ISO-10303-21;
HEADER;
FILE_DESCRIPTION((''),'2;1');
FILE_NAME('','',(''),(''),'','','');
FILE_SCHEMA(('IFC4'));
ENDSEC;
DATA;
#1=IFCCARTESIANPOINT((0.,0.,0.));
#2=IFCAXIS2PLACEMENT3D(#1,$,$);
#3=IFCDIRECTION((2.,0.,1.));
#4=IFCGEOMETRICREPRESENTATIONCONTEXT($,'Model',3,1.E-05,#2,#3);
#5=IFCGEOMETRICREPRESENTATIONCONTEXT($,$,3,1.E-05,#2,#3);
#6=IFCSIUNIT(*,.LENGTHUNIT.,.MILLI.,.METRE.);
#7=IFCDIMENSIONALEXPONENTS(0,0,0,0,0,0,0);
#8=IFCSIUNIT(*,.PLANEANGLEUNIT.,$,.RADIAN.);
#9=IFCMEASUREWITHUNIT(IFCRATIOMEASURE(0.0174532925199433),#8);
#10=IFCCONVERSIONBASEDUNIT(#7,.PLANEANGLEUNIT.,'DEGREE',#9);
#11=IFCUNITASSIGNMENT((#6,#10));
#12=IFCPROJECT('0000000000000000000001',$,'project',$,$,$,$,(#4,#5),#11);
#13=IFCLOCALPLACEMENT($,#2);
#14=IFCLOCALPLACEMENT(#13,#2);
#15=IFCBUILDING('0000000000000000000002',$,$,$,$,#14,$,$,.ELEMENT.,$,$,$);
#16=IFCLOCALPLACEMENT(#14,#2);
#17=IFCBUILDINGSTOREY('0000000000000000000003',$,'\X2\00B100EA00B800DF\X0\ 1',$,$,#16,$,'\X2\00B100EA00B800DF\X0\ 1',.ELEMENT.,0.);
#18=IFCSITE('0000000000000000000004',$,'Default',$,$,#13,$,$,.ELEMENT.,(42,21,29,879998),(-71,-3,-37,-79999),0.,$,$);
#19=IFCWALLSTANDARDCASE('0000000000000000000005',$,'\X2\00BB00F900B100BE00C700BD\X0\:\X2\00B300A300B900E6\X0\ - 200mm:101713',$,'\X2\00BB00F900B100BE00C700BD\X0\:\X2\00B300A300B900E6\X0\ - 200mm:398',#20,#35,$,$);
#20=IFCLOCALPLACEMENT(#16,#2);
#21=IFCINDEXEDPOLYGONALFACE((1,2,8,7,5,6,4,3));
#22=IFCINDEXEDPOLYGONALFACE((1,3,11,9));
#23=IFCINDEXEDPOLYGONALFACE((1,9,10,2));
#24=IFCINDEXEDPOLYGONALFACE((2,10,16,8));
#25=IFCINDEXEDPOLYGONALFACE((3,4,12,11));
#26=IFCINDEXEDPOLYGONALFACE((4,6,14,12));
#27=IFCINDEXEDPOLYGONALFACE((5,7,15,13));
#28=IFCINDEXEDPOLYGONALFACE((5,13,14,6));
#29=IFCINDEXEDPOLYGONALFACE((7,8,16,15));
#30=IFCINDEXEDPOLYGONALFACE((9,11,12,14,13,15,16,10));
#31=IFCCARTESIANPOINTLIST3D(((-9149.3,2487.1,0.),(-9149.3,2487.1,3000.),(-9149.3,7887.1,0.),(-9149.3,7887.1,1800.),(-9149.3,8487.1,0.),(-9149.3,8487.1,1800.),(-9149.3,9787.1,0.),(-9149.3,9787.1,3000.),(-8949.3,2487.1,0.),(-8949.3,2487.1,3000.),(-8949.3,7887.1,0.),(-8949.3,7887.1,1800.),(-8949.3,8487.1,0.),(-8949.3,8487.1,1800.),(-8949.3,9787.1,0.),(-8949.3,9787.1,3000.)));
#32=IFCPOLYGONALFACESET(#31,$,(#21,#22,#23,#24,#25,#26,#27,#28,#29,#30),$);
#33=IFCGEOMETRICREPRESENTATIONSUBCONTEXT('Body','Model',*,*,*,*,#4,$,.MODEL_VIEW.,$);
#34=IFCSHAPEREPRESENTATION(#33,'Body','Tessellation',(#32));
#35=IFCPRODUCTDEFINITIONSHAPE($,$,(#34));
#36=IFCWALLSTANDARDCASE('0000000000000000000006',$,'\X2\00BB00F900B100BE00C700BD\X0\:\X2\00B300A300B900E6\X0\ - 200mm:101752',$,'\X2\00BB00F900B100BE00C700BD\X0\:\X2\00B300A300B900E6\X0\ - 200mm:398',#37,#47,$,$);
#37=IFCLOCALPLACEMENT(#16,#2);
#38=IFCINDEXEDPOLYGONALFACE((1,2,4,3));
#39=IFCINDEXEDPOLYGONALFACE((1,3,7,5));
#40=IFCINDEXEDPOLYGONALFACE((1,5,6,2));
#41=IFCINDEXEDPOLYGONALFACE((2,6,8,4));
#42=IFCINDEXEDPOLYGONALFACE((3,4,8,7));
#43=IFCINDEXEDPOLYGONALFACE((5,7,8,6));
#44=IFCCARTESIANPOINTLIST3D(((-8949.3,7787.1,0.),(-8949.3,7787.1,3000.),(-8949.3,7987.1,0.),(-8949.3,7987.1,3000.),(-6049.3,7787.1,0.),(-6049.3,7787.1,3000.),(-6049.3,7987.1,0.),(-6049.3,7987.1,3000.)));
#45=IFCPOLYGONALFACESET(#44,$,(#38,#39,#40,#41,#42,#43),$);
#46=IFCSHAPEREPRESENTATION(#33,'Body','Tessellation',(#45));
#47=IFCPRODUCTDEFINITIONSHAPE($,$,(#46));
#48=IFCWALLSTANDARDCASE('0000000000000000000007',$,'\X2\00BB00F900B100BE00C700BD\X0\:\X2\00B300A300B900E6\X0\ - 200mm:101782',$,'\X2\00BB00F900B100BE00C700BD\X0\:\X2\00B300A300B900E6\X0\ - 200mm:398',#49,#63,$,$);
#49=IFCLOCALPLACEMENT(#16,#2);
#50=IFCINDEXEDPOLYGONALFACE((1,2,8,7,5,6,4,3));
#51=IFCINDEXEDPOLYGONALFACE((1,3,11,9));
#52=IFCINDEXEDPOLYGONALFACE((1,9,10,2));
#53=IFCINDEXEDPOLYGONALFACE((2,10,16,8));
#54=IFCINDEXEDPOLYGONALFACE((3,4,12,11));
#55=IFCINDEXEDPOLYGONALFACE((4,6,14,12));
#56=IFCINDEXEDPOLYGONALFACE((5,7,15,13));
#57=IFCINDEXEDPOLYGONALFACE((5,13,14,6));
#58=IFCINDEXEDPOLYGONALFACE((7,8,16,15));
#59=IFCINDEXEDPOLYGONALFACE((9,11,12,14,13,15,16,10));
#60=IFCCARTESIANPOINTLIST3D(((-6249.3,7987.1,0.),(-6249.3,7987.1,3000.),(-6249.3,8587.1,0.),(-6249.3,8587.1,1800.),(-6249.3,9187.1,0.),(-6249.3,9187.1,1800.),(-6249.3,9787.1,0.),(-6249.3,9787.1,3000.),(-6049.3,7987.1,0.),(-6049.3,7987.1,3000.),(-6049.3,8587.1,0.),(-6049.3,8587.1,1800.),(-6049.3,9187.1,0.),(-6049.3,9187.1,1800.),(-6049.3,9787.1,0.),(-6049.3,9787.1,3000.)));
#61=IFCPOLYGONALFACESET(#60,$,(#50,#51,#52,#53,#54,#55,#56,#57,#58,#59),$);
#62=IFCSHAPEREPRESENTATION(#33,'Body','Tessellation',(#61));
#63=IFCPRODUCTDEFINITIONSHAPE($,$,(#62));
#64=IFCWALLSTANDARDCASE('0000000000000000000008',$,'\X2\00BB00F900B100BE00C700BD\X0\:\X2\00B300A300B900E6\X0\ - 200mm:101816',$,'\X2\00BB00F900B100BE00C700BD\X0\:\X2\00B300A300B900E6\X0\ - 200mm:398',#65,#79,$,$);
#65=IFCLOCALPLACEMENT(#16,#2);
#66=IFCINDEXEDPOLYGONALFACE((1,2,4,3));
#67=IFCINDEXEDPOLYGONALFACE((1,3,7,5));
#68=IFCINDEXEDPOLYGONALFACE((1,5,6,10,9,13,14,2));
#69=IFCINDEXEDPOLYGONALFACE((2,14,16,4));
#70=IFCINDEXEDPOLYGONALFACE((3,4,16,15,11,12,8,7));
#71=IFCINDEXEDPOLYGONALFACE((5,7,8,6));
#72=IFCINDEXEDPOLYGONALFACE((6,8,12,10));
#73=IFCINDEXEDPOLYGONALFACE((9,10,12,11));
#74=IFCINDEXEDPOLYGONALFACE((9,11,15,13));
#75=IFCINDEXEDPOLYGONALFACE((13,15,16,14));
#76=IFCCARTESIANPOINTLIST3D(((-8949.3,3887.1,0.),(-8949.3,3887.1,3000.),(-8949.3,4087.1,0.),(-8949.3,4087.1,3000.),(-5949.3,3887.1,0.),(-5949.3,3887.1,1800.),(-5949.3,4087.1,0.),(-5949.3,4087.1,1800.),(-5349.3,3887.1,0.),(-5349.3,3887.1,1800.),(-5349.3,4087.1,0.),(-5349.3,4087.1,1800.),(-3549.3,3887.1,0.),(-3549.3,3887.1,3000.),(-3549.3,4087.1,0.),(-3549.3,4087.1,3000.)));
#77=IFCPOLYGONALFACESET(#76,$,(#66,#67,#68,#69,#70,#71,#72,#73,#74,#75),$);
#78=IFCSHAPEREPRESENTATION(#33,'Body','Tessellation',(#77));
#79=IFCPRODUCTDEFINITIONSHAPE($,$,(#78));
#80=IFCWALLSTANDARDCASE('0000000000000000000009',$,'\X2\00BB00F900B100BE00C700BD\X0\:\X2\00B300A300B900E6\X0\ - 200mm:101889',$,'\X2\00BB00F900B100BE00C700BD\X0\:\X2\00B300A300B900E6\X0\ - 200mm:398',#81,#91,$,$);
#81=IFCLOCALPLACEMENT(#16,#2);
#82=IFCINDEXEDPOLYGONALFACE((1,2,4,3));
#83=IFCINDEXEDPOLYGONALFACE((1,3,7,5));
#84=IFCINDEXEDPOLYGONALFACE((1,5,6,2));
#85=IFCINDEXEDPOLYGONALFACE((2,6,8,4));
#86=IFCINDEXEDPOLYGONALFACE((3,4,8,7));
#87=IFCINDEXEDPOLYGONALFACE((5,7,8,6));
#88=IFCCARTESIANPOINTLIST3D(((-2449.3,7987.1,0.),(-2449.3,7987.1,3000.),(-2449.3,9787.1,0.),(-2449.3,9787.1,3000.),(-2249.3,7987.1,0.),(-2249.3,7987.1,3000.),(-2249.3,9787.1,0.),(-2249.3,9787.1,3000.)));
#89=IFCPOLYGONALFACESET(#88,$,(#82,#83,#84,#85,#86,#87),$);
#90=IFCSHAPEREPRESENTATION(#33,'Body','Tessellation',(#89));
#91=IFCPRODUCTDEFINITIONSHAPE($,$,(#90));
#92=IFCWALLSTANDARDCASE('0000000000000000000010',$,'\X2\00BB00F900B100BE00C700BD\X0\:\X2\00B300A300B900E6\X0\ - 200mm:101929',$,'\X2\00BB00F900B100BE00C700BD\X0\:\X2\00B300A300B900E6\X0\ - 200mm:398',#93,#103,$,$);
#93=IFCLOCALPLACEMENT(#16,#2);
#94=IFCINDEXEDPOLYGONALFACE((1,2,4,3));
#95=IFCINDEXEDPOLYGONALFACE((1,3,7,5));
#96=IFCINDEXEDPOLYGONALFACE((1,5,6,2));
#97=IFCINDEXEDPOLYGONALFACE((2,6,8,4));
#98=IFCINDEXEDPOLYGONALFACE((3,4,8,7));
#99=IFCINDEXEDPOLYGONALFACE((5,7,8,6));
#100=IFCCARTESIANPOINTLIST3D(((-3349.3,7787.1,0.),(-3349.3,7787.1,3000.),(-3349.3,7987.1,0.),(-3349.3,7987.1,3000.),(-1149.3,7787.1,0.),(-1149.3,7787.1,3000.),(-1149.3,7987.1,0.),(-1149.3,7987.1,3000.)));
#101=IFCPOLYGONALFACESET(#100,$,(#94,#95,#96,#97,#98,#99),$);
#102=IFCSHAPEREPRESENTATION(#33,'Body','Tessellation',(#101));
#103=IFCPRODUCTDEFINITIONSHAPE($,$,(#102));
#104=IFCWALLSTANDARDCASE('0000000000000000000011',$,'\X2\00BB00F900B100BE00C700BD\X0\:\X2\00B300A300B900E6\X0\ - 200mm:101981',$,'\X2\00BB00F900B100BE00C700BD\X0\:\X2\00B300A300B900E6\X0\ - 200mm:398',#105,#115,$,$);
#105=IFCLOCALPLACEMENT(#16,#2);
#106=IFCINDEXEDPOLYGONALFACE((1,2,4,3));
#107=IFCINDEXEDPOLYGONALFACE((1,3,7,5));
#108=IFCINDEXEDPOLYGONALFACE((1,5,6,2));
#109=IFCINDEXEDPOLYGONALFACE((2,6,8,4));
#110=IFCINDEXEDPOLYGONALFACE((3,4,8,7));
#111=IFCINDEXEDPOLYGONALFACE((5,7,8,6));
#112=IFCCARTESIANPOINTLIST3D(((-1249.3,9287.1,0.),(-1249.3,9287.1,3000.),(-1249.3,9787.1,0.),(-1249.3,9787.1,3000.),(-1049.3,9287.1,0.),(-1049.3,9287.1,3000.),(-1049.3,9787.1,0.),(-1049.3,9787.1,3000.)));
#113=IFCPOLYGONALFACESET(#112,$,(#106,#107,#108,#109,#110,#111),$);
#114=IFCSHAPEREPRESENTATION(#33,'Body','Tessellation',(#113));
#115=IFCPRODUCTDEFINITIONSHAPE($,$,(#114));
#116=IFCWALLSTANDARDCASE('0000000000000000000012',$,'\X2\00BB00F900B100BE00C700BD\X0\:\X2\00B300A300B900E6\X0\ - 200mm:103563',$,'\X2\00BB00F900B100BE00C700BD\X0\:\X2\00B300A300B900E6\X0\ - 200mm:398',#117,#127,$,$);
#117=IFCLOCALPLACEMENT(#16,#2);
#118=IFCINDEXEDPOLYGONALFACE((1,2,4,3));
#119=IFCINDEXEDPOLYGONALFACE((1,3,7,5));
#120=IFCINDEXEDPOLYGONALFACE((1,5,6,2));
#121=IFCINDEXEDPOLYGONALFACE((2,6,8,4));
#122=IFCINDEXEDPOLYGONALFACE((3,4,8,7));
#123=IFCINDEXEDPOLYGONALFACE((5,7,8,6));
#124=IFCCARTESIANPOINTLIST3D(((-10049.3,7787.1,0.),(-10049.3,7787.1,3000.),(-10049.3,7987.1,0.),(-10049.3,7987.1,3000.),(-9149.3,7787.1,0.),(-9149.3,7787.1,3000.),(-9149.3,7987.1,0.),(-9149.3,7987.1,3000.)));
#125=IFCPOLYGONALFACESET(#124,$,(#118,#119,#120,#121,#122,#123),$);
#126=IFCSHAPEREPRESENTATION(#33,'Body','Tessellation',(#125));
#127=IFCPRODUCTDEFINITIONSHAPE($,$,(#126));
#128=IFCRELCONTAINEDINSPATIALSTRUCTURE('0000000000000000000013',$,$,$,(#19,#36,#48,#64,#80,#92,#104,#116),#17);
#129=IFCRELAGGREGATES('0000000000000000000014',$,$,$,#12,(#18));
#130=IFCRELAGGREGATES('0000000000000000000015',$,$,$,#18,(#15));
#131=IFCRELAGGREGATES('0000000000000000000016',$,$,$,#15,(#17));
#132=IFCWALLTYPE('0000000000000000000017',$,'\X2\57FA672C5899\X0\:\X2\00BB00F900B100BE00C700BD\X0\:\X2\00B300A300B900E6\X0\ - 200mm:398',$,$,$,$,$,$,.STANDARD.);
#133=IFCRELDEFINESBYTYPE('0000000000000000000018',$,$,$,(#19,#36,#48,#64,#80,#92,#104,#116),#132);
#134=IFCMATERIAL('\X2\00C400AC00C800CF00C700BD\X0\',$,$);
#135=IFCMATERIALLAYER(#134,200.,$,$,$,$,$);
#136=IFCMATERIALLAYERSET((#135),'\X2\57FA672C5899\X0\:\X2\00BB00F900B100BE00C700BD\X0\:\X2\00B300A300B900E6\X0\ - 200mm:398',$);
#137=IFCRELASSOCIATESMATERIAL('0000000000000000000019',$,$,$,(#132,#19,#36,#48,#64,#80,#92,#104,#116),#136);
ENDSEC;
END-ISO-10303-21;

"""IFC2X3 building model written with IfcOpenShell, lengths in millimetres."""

from ifc_helpers import new_model, entity, si_unit, converted_unit, direction, frame, frame_2d, origin, origin_2d_with_axis, place, context, subcontext, project, spatial, rectangle, extrude, material, layer, layer_set, layer_usage, type_object, element, save


model = new_model("IFC2X3")

# Units and contexts
model_context = context("Model", 3, precision=1e-05, world=origin(), true_north=direction((2.0, 0.0, 1.0)))
context_of_model = context(None, 3, precision=1e-05, world=origin(), true_north=direction((2.0, 0.0, 1.0)))
body_context = subcontext(model_context, "Body", "Model", "MODEL_VIEW")
ifc_project = project(units=[si_unit("LENGTHUNIT", "METRE", prefix="MILLI"), converted_unit("PLANEANGLEUNIT", "DEGREE", entity("IfcRatioMeasure", 0.0174532925199433), si_unit("PLANEANGLEUNIT", "RADIAN"), dimensions=[0, 0, 0, 0, 0, 0, 0])], contexts=[model_context, context_of_model])

# Site, building, storey
site_placement = place(None, origin())
site = spatial("IfcSite", under=ifc_project, at=site_placement, Name="Default", CompositionType="ELEMENT", RefLatitude=(42, 21, 29, 879998), RefLongitude=(-71, -3, -37, -79999), RefElevation=0.0)
building_placement = place(site_placement, origin())
building = spatial("IfcBuilding", under=site, at=building_placement, CompositionType="ELEMENT")
storey_placement = place(building_placement, origin())
storey = spatial("IfcBuildingStorey", under=building, at=storey_placement, Name="±ê¸ß 1", LongName="±ê¸ß 1", CompositionType="ELEMENT", Elevation=0.0)

# Shared definitions
ifc_material = material(Name="Ä¬ÈÏÇ½")
ifc_layer = layer(ifc_material, 200.0)
ifc_layer_set = layer_set([ifc_layer], Name="基本墙:»ù±¾Ç½:³£¹æ - 200mm:398")
wall_type = type_object("IfcWallType", Name="基本墙:»ù±¾Ç½:³£¹æ - 200mm:398", PredefinedType="STANDARD", material=ifc_layer_set)

# Wall, opening
ifc_layer_usage_1 = layer_usage(ifc_layer_set, "AXIS2", "NEGATIVE", 100.0)
wall_1_placement = place(storey_placement, frame((-9049.3, 9787.1, 0.0), z_axis=(0.0, 0.0, 1.0), x_axis=(0.0, -1.0, 0.0)))
wall_1 = element("IfcWallStandardCase", 1, at=wall_1_placement, inside=storey, type_object=wall_type, material=ifc_layer_usage_1, Name="»ù±¾Ç½:³£¹æ - 200mm:101713", ObjectType="»ù±¾Ç½:³£¹æ - 200mm:398", context=body_context, shape_type="SweptSolid", body=[
    extrude(rectangle(XDim=7300.0, YDim=200.0, at=frame_2d((3650.0, 0.0), x_axis=(-1.0, 0.0))), origin(), (0.0, 0.0, 1.0), 3000.0),
])
opening_1_placement = place(wall_1_placement, origin())
element("IfcOpeningElement", 2, at=opening_1_placement, cuts=wall_1, ObjectType="Opening", context=body_context, shape_type="SweptSolid", body=[
    extrude(rectangle(XDim=1800.0, YDim=600.0, at=origin_2d_with_axis()), frame((1600.0, -102.0, 900.0), z_axis=(0.0, 1.0, 0.0), x_axis=(0.0, 0.0, -1.0)), (0.0, 0.0, 1.0), 204.0),
])

# Wall
ifc_layer_usage_2 = layer_usage(ifc_layer_set, "AXIS2", "NEGATIVE", 100.0)
wall_2_placement = place(storey_placement, frame((-8949.3, 7887.1, 0.0)))
element("IfcWallStandardCase", 3, at=wall_2_placement, inside=storey, type_object=wall_type, material=ifc_layer_usage_2, Name="»ù±¾Ç½:³£¹æ - 200mm:101752", ObjectType="»ù±¾Ç½:³£¹æ - 200mm:398", context=body_context, shape_type="SweptSolid", body=[
    extrude(rectangle(XDim=2900.0, YDim=200.0, at=frame_2d((1450.0, 0.0), x_axis=(-1.0, 0.0))), origin(), (0.0, 0.0, 1.0), 3000.0),
])

# Walls, openings
ifc_layer_usage_3 = layer_usage(ifc_layer_set, "AXIS2", "NEGATIVE", 100.0)
wall_3_placement = place(storey_placement, frame((-6149.3, 7987.1, 0.0), z_axis=(0.0, 0.0, 1.0), x_axis=(0.0, 1.0, 0.0)))
wall_3 = element("IfcWallStandardCase", 4, at=wall_3_placement, inside=storey, type_object=wall_type, material=ifc_layer_usage_3, Name="»ù±¾Ç½:³£¹æ - 200mm:101782", ObjectType="»ù±¾Ç½:³£¹æ - 200mm:398", context=body_context, shape_type="SweptSolid", body=[
    extrude(rectangle(XDim=1800.0, YDim=200.0, at=frame_2d((900.0, 0.0), x_axis=(-1.0, 0.0))), origin(), (0.0, 0.0, 1.0), 3000.0),
])
opening_2_placement = place(wall_3_placement, origin())
element("IfcOpeningElement", 5, at=opening_2_placement, cuts=wall_3, ObjectType="Opening", context=body_context, shape_type="SweptSolid", body=[
    extrude(rectangle(XDim=1800.0, YDim=600.0, at=frame_2d((0.0, 0.0), x_axis=(0.0, 1.0))), frame((900.0, -102.0, 900.0), z_axis=(0.0, 1.0, 0.0), x_axis=(1.0, 0.0, 0.0)), (0.0, 0.0, 1.0), 204.0),
])
ifc_layer_usage_4 = layer_usage(ifc_layer_set, "AXIS2", "NEGATIVE", 100.0)
wall_4_placement = place(storey_placement, frame((-8949.3, 3987.1, 0.0)))
wall_4 = element("IfcWallStandardCase", 6, at=wall_4_placement, inside=storey, type_object=wall_type, material=ifc_layer_usage_4, Name="»ù±¾Ç½:³£¹æ - 200mm:101816", ObjectType="»ù±¾Ç½:³£¹æ - 200mm:398", context=body_context, shape_type="SweptSolid", body=[
    extrude(rectangle(XDim=5400.0, YDim=200.0, at=frame_2d((2700.0, 0.0), x_axis=(-1.0, 0.0))), origin(), (0.0, 0.0, 1.0), 3000.0),
])
opening_3_placement = place(wall_4_placement, origin())
element("IfcOpeningElement", 7, at=opening_3_placement, cuts=wall_4, ObjectType="Opening", context=body_context, shape_type="SweptSolid", body=[
    extrude(rectangle(XDim=1800.0, YDim=600.0, at=frame_2d((0.0, 0.0), x_axis=(0.0, 1.0))), frame((3300.0, -102.0, 900.0), z_axis=(0.0, 1.0, 0.0), x_axis=(1.0, 0.0, 0.0)), (0.0, 0.0, 1.0), 204.0),
])

# Walls
ifc_layer_usage_5 = layer_usage(ifc_layer_set, "AXIS2", "NEGATIVE", 100.0)
wall_5_placement = place(storey_placement, frame((-2349.3, 9787.1, 0.0), z_axis=(0.0, 0.0, 1.0), x_axis=(0.0, -1.0, 0.0)))
element("IfcWallStandardCase", 8, at=wall_5_placement, inside=storey, type_object=wall_type, material=ifc_layer_usage_5, Name="»ù±¾Ç½:³£¹æ - 200mm:101889", ObjectType="»ù±¾Ç½:³£¹æ - 200mm:398", context=body_context, shape_type="SweptSolid", body=[
    extrude(rectangle(XDim=1800.0, YDim=200.0, at=frame_2d((900.0, 0.0), x_axis=(-1.0, 0.0))), origin(), (0.0, 0.0, 1.0), 3000.0),
])
ifc_layer_usage_6 = layer_usage(ifc_layer_set, "AXIS2", "NEGATIVE", 100.0)
wall_6_placement = place(storey_placement, frame((-3349.3, 7887.1, 0.0)))
element("IfcWallStandardCase", 9, at=wall_6_placement, inside=storey, type_object=wall_type, material=ifc_layer_usage_6, Name="»ù±¾Ç½:³£¹æ - 200mm:101929", ObjectType="»ù±¾Ç½:³£¹æ - 200mm:398", context=body_context, shape_type="SweptSolid", body=[
    extrude(rectangle(XDim=2200.0, YDim=200.0, at=frame_2d((1100.0, 0.0), x_axis=(-1.0, 0.0))), origin(), (0.0, 0.0, 1.0), 3000.0),
])
ifc_layer_usage_7 = layer_usage(ifc_layer_set, "AXIS2", "NEGATIVE", 100.0)
wall_7_placement = place(storey_placement, frame((-1149.3, 9787.1, 0.0), z_axis=(0.0, 0.0, 1.0), x_axis=(0.0, -1.0, 0.0)))
element("IfcWallStandardCase", 10, at=wall_7_placement, inside=storey, type_object=wall_type, material=ifc_layer_usage_7, Name="»ù±¾Ç½:³£¹æ - 200mm:101981", ObjectType="»ù±¾Ç½:³£¹æ - 200mm:398", context=body_context, shape_type="SweptSolid", body=[
    extrude(rectangle(XDim=500.0, YDim=200.0, at=frame_2d((250.0, 0.0), x_axis=(-1.0, 0.0))), origin(), (0.0, 0.0, 1.0), 3000.0),
])
ifc_layer_usage_8 = layer_usage(ifc_layer_set, "AXIS2", "NEGATIVE", 100.0)
wall_8_placement = place(storey_placement, frame((-10049.3, 7887.1, 0.0)))
element("IfcWallStandardCase", 11, at=wall_8_placement, inside=storey, type_object=wall_type, material=ifc_layer_usage_8, Name="»ù±¾Ç½:³£¹æ - 200mm:103563", ObjectType="»ù±¾Ç½:³£¹æ - 200mm:398", context=body_context, shape_type="SweptSolid", body=[
    extrude(rectangle(XDim=900.0, YDim=200.0, at=frame_2d((450.0, 0.0), x_axis=(-1.0, 0.0))), origin(), (0.0, 0.0, 1.0), 3000.0),
])

save(model, "model.ifc")
